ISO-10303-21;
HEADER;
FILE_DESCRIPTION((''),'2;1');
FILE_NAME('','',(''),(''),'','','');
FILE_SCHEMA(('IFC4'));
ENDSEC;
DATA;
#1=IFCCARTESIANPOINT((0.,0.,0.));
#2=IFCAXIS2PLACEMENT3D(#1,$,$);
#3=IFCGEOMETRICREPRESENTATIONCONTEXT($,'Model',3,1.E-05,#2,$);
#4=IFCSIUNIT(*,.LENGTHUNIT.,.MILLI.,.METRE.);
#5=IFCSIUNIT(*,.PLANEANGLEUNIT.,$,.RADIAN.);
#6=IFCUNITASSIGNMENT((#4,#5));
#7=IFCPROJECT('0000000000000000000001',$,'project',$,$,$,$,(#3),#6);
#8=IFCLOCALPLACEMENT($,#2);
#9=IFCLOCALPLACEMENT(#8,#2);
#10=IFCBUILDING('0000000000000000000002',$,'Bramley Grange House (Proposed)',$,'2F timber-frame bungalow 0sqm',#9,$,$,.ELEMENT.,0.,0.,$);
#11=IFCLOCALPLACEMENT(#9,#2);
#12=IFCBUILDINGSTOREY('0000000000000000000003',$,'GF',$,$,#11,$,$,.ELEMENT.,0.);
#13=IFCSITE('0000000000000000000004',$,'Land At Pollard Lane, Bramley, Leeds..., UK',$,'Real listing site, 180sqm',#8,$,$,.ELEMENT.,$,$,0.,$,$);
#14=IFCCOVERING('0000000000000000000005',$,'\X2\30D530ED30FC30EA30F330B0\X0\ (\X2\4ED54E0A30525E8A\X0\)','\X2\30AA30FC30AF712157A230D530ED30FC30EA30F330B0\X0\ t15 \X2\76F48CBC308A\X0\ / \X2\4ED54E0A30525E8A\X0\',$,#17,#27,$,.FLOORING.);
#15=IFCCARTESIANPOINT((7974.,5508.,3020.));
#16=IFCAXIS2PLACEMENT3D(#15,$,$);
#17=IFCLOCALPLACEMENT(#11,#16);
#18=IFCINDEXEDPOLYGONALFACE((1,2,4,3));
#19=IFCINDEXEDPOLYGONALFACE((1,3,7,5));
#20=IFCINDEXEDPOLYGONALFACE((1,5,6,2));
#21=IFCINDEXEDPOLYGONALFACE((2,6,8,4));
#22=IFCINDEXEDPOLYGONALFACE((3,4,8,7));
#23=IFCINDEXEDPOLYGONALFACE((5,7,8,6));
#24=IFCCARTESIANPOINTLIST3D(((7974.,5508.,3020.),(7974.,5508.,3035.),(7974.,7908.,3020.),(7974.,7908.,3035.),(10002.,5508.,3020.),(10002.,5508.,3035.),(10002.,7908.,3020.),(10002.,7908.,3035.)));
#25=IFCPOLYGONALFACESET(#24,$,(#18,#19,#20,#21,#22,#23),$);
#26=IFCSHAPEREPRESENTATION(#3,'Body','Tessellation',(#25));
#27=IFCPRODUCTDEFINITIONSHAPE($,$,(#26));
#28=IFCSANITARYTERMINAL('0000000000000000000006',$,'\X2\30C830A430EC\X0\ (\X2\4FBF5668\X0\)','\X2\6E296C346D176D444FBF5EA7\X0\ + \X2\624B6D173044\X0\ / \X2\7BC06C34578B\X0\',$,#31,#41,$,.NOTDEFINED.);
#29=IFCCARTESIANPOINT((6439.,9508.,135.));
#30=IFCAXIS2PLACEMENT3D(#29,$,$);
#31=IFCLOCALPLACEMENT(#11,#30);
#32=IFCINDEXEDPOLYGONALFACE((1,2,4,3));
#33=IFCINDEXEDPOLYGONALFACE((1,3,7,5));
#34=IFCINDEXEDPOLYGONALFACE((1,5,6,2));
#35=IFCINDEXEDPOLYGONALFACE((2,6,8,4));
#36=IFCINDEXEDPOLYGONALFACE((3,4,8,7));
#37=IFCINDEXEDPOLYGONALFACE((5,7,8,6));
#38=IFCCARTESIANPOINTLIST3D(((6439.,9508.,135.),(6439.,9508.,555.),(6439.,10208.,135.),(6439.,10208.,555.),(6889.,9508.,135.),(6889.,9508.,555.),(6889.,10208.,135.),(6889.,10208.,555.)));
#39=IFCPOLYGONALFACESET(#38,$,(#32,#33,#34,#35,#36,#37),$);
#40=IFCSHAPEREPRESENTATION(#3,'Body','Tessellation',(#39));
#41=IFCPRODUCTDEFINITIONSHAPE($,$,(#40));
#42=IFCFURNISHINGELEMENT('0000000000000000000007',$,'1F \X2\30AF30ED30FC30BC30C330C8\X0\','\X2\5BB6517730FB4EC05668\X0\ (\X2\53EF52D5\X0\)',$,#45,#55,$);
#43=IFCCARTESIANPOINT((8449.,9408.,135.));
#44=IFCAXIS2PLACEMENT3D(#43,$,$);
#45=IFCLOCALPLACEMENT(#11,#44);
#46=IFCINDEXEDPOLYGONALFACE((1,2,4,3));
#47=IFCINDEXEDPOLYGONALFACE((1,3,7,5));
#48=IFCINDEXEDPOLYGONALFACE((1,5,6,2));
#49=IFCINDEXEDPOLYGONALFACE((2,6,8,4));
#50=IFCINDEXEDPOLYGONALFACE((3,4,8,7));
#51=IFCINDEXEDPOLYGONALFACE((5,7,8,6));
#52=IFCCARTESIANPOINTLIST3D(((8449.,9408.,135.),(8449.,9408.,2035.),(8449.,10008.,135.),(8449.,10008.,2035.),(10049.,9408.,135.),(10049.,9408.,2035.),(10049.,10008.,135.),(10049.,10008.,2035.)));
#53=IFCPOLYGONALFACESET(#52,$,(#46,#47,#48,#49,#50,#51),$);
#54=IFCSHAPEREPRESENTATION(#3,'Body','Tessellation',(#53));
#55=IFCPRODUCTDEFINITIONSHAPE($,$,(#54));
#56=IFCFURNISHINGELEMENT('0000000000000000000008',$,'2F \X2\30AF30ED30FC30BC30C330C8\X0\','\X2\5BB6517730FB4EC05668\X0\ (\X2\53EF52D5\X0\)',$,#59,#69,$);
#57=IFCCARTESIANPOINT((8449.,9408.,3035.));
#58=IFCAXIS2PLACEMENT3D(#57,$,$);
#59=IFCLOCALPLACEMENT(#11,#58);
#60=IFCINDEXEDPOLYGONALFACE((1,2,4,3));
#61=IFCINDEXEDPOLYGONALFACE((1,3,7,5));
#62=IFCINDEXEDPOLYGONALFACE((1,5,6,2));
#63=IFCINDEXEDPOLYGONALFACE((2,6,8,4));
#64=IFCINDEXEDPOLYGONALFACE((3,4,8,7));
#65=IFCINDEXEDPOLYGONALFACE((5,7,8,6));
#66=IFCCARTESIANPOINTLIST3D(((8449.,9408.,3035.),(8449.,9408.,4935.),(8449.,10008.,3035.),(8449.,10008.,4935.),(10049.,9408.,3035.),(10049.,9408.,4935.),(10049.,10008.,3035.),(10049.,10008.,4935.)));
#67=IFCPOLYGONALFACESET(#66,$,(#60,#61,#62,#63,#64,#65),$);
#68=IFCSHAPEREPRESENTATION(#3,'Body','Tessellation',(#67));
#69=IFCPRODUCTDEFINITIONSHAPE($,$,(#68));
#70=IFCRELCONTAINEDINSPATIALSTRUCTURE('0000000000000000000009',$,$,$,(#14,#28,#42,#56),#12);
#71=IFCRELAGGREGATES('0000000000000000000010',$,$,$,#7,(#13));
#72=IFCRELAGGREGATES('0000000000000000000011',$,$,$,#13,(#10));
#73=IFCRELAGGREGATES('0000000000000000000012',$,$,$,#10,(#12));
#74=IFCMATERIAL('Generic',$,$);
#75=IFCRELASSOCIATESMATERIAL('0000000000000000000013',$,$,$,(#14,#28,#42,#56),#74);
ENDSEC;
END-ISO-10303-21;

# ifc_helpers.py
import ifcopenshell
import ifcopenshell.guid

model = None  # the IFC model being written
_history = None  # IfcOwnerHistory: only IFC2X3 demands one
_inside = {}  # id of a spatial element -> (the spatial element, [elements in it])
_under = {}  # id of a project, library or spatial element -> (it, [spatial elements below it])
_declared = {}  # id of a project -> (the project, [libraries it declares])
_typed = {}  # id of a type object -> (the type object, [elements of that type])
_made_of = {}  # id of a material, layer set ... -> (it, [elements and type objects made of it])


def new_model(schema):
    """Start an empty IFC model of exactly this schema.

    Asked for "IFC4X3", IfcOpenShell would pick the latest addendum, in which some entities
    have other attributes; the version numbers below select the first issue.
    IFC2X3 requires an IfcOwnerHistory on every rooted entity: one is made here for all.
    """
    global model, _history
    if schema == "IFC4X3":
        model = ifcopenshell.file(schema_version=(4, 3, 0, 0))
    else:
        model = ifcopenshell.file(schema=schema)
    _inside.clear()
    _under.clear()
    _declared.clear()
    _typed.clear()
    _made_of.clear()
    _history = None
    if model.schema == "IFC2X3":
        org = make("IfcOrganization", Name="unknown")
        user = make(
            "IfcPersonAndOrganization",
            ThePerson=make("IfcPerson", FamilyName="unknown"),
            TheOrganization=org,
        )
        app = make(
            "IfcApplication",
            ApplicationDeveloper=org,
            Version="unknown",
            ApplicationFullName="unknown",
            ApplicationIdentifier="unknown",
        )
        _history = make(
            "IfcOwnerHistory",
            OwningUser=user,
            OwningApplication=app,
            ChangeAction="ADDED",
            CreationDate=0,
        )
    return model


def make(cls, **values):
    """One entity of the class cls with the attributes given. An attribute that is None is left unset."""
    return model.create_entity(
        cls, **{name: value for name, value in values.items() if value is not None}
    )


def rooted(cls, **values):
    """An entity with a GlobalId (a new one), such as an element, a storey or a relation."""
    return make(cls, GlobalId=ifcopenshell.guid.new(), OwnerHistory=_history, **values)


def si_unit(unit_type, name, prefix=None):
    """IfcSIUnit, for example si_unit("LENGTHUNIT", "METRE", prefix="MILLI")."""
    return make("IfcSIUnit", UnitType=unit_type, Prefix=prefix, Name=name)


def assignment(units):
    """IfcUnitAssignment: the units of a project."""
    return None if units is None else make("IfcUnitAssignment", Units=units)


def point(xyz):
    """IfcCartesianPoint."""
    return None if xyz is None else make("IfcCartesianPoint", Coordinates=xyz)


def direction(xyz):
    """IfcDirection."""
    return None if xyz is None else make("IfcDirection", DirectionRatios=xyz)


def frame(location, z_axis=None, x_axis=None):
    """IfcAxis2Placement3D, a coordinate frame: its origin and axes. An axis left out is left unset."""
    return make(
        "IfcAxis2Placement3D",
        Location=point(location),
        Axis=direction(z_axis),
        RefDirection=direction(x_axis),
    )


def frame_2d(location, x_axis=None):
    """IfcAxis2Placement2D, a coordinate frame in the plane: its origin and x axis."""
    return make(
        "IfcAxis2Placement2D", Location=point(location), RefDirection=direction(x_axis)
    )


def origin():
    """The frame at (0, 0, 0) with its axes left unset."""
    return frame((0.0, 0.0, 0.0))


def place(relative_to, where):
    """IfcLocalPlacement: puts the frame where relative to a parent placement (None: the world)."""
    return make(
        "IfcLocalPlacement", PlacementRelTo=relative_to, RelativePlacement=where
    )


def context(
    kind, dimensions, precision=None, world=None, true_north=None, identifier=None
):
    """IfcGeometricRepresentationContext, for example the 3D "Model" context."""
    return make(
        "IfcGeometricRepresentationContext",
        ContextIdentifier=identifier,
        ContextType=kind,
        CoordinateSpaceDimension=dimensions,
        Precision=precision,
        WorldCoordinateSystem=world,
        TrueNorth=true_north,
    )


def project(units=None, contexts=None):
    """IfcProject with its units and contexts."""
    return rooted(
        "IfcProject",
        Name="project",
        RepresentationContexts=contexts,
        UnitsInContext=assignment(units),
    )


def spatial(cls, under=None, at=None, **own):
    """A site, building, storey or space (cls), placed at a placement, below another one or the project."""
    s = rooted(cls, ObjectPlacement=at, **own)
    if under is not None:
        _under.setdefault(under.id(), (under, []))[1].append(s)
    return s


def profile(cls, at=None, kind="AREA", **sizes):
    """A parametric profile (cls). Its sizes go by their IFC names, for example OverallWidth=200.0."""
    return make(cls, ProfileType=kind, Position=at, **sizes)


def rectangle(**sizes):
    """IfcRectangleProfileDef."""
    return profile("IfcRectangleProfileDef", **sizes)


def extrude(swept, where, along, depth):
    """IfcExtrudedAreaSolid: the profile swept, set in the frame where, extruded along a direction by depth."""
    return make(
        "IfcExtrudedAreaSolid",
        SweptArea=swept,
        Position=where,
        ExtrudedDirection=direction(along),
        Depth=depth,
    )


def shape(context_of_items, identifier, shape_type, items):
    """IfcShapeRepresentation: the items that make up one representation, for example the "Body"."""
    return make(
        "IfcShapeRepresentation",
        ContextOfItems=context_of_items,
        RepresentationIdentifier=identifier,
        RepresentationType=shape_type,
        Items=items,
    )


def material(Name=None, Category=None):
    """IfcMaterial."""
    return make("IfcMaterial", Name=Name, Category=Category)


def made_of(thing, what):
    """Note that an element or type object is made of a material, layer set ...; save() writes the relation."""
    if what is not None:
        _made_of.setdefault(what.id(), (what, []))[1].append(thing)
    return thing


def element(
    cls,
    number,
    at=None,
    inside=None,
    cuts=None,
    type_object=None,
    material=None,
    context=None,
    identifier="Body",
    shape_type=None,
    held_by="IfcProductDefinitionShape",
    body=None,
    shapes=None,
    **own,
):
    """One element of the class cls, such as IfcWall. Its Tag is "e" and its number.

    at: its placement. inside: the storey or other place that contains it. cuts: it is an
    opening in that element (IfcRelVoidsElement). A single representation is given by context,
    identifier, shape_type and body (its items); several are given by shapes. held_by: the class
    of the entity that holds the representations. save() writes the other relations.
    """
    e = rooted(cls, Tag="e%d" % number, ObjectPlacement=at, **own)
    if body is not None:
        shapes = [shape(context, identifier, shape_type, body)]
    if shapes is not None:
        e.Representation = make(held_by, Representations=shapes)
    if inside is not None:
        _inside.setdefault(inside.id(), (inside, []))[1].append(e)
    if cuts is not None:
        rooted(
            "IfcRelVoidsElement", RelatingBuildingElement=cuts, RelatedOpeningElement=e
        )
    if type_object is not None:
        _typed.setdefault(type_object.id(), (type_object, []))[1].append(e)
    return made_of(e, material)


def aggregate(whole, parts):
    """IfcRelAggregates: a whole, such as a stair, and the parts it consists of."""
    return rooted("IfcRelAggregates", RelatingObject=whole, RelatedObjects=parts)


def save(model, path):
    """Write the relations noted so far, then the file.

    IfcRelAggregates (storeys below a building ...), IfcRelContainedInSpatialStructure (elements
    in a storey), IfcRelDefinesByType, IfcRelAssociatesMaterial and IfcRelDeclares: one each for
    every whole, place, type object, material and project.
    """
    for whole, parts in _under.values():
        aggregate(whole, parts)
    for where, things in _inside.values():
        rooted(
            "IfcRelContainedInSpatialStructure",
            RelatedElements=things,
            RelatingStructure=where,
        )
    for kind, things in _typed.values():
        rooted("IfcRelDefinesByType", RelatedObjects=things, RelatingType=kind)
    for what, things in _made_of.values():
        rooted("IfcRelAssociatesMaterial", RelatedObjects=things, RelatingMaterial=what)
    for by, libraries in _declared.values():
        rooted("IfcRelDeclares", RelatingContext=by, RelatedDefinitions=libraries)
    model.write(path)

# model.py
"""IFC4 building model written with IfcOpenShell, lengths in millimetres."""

from ifc_helpers import new_model, si_unit, frame, frame_2d, origin, place, context, project, spatial, rectangle, extrude, material, element, save


model = new_model("IFC4")

# Units and contexts
model_context = context("Model", 3, precision=1e-05, world=origin())
ifc_project = project(units=[si_unit("LENGTHUNIT", "METRE", prefix="MILLI"), si_unit("PLANEANGLEUNIT", "RADIAN")], contexts=[model_context])

# Site, building, storey
site_placement = place(None, origin())
site = spatial("IfcSite", under=ifc_project, at=site_placement, Name="Land At Pollard Lane, Bramley, Leeds..., UK", ObjectType="Real listing site, 180sqm", CompositionType="ELEMENT", RefElevation=0.0)
building_placement = place(site_placement, origin())
building = spatial("IfcBuilding", under=site, at=building_placement, Name="Bramley Grange House (Proposed)", ObjectType="2F timber-frame bungalow 0sqm", CompositionType="ELEMENT", ElevationOfRefHeight=0.0, ElevationOfTerrain=0.0)
storey_placement = place(building_placement, origin())
storey = spatial("IfcBuildingStorey", under=building, at=storey_placement, Name="GF", CompositionType="ELEMENT", Elevation=0.0)

# Covering
ifc_material_1 = material(Name="Generic")
covering_1_placement = place(storey_placement, frame((7974.0, 5508.0, 3020.0)))
element("IfcCovering", 1, at=covering_1_placement, inside=storey, material=ifc_material_1, Name="フローリング (仕上げ床)", Description="オーク無垢フローリング t15 直貼り / 仕上げ床", PredefinedType="FLOORING", context=model_context, shape_type="SweptSolid", body=[
    extrude(rectangle(XDim=2028.0, YDim=2400.0, at=frame_2d((1014.0, 1200.0))), frame((7974.0, 5508.0, 3020.0)), (0.0, 0.0, 1.0), 15.0),
])

# Sanitary terminal
sanitary_terminal_placement = place(storey_placement, frame((6439.0, 9508.0, 135.0)))
element("IfcSanitaryTerminal", 2, at=sanitary_terminal_placement, inside=storey, material=ifc_material_1, Name="トイレ (便器)", Description="温水洗浄便座 + 手洗い / 節水型", PredefinedType="NOTDEFINED", context=model_context, shape_type="SweptSolid", body=[
    extrude(rectangle(XDim=450.0, YDim=700.0, at=frame_2d((225.0, 350.0))), frame((6439.0, 9508.0, 135.0)), (0.0, 0.0, 1.0), 420.0),
])

# Furnishing elements
furnishing_1_placement = place(storey_placement, frame((8449.0, 9408.0, 135.0)))
element("IfcFurnishingElement", 3, at=furnishing_1_placement, inside=storey, material=ifc_material_1, Name="1F クローゼット", Description="家具・什器 (可動)", context=model_context, shape_type="SweptSolid", body=[
    extrude(rectangle(XDim=1600.0, YDim=600.0, at=frame_2d((800.0, 300.0))), frame((8449.0, 9408.0, 135.0)), (0.0, 0.0, 1.0), 1900.0),
])
furnishing_2_placement = place(storey_placement, frame((8449.0, 9408.0, 3035.0)))
element("IfcFurnishingElement", 4, at=furnishing_2_placement, inside=storey, material=ifc_material_1, Name="2F クローゼット", Description="家具・什器 (可動)", context=model_context, shape_type="SweptSolid", body=[
    extrude(rectangle(XDim=1600.0, YDim=600.0, at=frame_2d((800.0, 300.0))), frame((8449.0, 9408.0, 3035.0)), (0.0, 0.0, 1.0), 1900.0),
])

save(model, "model.ifc")
